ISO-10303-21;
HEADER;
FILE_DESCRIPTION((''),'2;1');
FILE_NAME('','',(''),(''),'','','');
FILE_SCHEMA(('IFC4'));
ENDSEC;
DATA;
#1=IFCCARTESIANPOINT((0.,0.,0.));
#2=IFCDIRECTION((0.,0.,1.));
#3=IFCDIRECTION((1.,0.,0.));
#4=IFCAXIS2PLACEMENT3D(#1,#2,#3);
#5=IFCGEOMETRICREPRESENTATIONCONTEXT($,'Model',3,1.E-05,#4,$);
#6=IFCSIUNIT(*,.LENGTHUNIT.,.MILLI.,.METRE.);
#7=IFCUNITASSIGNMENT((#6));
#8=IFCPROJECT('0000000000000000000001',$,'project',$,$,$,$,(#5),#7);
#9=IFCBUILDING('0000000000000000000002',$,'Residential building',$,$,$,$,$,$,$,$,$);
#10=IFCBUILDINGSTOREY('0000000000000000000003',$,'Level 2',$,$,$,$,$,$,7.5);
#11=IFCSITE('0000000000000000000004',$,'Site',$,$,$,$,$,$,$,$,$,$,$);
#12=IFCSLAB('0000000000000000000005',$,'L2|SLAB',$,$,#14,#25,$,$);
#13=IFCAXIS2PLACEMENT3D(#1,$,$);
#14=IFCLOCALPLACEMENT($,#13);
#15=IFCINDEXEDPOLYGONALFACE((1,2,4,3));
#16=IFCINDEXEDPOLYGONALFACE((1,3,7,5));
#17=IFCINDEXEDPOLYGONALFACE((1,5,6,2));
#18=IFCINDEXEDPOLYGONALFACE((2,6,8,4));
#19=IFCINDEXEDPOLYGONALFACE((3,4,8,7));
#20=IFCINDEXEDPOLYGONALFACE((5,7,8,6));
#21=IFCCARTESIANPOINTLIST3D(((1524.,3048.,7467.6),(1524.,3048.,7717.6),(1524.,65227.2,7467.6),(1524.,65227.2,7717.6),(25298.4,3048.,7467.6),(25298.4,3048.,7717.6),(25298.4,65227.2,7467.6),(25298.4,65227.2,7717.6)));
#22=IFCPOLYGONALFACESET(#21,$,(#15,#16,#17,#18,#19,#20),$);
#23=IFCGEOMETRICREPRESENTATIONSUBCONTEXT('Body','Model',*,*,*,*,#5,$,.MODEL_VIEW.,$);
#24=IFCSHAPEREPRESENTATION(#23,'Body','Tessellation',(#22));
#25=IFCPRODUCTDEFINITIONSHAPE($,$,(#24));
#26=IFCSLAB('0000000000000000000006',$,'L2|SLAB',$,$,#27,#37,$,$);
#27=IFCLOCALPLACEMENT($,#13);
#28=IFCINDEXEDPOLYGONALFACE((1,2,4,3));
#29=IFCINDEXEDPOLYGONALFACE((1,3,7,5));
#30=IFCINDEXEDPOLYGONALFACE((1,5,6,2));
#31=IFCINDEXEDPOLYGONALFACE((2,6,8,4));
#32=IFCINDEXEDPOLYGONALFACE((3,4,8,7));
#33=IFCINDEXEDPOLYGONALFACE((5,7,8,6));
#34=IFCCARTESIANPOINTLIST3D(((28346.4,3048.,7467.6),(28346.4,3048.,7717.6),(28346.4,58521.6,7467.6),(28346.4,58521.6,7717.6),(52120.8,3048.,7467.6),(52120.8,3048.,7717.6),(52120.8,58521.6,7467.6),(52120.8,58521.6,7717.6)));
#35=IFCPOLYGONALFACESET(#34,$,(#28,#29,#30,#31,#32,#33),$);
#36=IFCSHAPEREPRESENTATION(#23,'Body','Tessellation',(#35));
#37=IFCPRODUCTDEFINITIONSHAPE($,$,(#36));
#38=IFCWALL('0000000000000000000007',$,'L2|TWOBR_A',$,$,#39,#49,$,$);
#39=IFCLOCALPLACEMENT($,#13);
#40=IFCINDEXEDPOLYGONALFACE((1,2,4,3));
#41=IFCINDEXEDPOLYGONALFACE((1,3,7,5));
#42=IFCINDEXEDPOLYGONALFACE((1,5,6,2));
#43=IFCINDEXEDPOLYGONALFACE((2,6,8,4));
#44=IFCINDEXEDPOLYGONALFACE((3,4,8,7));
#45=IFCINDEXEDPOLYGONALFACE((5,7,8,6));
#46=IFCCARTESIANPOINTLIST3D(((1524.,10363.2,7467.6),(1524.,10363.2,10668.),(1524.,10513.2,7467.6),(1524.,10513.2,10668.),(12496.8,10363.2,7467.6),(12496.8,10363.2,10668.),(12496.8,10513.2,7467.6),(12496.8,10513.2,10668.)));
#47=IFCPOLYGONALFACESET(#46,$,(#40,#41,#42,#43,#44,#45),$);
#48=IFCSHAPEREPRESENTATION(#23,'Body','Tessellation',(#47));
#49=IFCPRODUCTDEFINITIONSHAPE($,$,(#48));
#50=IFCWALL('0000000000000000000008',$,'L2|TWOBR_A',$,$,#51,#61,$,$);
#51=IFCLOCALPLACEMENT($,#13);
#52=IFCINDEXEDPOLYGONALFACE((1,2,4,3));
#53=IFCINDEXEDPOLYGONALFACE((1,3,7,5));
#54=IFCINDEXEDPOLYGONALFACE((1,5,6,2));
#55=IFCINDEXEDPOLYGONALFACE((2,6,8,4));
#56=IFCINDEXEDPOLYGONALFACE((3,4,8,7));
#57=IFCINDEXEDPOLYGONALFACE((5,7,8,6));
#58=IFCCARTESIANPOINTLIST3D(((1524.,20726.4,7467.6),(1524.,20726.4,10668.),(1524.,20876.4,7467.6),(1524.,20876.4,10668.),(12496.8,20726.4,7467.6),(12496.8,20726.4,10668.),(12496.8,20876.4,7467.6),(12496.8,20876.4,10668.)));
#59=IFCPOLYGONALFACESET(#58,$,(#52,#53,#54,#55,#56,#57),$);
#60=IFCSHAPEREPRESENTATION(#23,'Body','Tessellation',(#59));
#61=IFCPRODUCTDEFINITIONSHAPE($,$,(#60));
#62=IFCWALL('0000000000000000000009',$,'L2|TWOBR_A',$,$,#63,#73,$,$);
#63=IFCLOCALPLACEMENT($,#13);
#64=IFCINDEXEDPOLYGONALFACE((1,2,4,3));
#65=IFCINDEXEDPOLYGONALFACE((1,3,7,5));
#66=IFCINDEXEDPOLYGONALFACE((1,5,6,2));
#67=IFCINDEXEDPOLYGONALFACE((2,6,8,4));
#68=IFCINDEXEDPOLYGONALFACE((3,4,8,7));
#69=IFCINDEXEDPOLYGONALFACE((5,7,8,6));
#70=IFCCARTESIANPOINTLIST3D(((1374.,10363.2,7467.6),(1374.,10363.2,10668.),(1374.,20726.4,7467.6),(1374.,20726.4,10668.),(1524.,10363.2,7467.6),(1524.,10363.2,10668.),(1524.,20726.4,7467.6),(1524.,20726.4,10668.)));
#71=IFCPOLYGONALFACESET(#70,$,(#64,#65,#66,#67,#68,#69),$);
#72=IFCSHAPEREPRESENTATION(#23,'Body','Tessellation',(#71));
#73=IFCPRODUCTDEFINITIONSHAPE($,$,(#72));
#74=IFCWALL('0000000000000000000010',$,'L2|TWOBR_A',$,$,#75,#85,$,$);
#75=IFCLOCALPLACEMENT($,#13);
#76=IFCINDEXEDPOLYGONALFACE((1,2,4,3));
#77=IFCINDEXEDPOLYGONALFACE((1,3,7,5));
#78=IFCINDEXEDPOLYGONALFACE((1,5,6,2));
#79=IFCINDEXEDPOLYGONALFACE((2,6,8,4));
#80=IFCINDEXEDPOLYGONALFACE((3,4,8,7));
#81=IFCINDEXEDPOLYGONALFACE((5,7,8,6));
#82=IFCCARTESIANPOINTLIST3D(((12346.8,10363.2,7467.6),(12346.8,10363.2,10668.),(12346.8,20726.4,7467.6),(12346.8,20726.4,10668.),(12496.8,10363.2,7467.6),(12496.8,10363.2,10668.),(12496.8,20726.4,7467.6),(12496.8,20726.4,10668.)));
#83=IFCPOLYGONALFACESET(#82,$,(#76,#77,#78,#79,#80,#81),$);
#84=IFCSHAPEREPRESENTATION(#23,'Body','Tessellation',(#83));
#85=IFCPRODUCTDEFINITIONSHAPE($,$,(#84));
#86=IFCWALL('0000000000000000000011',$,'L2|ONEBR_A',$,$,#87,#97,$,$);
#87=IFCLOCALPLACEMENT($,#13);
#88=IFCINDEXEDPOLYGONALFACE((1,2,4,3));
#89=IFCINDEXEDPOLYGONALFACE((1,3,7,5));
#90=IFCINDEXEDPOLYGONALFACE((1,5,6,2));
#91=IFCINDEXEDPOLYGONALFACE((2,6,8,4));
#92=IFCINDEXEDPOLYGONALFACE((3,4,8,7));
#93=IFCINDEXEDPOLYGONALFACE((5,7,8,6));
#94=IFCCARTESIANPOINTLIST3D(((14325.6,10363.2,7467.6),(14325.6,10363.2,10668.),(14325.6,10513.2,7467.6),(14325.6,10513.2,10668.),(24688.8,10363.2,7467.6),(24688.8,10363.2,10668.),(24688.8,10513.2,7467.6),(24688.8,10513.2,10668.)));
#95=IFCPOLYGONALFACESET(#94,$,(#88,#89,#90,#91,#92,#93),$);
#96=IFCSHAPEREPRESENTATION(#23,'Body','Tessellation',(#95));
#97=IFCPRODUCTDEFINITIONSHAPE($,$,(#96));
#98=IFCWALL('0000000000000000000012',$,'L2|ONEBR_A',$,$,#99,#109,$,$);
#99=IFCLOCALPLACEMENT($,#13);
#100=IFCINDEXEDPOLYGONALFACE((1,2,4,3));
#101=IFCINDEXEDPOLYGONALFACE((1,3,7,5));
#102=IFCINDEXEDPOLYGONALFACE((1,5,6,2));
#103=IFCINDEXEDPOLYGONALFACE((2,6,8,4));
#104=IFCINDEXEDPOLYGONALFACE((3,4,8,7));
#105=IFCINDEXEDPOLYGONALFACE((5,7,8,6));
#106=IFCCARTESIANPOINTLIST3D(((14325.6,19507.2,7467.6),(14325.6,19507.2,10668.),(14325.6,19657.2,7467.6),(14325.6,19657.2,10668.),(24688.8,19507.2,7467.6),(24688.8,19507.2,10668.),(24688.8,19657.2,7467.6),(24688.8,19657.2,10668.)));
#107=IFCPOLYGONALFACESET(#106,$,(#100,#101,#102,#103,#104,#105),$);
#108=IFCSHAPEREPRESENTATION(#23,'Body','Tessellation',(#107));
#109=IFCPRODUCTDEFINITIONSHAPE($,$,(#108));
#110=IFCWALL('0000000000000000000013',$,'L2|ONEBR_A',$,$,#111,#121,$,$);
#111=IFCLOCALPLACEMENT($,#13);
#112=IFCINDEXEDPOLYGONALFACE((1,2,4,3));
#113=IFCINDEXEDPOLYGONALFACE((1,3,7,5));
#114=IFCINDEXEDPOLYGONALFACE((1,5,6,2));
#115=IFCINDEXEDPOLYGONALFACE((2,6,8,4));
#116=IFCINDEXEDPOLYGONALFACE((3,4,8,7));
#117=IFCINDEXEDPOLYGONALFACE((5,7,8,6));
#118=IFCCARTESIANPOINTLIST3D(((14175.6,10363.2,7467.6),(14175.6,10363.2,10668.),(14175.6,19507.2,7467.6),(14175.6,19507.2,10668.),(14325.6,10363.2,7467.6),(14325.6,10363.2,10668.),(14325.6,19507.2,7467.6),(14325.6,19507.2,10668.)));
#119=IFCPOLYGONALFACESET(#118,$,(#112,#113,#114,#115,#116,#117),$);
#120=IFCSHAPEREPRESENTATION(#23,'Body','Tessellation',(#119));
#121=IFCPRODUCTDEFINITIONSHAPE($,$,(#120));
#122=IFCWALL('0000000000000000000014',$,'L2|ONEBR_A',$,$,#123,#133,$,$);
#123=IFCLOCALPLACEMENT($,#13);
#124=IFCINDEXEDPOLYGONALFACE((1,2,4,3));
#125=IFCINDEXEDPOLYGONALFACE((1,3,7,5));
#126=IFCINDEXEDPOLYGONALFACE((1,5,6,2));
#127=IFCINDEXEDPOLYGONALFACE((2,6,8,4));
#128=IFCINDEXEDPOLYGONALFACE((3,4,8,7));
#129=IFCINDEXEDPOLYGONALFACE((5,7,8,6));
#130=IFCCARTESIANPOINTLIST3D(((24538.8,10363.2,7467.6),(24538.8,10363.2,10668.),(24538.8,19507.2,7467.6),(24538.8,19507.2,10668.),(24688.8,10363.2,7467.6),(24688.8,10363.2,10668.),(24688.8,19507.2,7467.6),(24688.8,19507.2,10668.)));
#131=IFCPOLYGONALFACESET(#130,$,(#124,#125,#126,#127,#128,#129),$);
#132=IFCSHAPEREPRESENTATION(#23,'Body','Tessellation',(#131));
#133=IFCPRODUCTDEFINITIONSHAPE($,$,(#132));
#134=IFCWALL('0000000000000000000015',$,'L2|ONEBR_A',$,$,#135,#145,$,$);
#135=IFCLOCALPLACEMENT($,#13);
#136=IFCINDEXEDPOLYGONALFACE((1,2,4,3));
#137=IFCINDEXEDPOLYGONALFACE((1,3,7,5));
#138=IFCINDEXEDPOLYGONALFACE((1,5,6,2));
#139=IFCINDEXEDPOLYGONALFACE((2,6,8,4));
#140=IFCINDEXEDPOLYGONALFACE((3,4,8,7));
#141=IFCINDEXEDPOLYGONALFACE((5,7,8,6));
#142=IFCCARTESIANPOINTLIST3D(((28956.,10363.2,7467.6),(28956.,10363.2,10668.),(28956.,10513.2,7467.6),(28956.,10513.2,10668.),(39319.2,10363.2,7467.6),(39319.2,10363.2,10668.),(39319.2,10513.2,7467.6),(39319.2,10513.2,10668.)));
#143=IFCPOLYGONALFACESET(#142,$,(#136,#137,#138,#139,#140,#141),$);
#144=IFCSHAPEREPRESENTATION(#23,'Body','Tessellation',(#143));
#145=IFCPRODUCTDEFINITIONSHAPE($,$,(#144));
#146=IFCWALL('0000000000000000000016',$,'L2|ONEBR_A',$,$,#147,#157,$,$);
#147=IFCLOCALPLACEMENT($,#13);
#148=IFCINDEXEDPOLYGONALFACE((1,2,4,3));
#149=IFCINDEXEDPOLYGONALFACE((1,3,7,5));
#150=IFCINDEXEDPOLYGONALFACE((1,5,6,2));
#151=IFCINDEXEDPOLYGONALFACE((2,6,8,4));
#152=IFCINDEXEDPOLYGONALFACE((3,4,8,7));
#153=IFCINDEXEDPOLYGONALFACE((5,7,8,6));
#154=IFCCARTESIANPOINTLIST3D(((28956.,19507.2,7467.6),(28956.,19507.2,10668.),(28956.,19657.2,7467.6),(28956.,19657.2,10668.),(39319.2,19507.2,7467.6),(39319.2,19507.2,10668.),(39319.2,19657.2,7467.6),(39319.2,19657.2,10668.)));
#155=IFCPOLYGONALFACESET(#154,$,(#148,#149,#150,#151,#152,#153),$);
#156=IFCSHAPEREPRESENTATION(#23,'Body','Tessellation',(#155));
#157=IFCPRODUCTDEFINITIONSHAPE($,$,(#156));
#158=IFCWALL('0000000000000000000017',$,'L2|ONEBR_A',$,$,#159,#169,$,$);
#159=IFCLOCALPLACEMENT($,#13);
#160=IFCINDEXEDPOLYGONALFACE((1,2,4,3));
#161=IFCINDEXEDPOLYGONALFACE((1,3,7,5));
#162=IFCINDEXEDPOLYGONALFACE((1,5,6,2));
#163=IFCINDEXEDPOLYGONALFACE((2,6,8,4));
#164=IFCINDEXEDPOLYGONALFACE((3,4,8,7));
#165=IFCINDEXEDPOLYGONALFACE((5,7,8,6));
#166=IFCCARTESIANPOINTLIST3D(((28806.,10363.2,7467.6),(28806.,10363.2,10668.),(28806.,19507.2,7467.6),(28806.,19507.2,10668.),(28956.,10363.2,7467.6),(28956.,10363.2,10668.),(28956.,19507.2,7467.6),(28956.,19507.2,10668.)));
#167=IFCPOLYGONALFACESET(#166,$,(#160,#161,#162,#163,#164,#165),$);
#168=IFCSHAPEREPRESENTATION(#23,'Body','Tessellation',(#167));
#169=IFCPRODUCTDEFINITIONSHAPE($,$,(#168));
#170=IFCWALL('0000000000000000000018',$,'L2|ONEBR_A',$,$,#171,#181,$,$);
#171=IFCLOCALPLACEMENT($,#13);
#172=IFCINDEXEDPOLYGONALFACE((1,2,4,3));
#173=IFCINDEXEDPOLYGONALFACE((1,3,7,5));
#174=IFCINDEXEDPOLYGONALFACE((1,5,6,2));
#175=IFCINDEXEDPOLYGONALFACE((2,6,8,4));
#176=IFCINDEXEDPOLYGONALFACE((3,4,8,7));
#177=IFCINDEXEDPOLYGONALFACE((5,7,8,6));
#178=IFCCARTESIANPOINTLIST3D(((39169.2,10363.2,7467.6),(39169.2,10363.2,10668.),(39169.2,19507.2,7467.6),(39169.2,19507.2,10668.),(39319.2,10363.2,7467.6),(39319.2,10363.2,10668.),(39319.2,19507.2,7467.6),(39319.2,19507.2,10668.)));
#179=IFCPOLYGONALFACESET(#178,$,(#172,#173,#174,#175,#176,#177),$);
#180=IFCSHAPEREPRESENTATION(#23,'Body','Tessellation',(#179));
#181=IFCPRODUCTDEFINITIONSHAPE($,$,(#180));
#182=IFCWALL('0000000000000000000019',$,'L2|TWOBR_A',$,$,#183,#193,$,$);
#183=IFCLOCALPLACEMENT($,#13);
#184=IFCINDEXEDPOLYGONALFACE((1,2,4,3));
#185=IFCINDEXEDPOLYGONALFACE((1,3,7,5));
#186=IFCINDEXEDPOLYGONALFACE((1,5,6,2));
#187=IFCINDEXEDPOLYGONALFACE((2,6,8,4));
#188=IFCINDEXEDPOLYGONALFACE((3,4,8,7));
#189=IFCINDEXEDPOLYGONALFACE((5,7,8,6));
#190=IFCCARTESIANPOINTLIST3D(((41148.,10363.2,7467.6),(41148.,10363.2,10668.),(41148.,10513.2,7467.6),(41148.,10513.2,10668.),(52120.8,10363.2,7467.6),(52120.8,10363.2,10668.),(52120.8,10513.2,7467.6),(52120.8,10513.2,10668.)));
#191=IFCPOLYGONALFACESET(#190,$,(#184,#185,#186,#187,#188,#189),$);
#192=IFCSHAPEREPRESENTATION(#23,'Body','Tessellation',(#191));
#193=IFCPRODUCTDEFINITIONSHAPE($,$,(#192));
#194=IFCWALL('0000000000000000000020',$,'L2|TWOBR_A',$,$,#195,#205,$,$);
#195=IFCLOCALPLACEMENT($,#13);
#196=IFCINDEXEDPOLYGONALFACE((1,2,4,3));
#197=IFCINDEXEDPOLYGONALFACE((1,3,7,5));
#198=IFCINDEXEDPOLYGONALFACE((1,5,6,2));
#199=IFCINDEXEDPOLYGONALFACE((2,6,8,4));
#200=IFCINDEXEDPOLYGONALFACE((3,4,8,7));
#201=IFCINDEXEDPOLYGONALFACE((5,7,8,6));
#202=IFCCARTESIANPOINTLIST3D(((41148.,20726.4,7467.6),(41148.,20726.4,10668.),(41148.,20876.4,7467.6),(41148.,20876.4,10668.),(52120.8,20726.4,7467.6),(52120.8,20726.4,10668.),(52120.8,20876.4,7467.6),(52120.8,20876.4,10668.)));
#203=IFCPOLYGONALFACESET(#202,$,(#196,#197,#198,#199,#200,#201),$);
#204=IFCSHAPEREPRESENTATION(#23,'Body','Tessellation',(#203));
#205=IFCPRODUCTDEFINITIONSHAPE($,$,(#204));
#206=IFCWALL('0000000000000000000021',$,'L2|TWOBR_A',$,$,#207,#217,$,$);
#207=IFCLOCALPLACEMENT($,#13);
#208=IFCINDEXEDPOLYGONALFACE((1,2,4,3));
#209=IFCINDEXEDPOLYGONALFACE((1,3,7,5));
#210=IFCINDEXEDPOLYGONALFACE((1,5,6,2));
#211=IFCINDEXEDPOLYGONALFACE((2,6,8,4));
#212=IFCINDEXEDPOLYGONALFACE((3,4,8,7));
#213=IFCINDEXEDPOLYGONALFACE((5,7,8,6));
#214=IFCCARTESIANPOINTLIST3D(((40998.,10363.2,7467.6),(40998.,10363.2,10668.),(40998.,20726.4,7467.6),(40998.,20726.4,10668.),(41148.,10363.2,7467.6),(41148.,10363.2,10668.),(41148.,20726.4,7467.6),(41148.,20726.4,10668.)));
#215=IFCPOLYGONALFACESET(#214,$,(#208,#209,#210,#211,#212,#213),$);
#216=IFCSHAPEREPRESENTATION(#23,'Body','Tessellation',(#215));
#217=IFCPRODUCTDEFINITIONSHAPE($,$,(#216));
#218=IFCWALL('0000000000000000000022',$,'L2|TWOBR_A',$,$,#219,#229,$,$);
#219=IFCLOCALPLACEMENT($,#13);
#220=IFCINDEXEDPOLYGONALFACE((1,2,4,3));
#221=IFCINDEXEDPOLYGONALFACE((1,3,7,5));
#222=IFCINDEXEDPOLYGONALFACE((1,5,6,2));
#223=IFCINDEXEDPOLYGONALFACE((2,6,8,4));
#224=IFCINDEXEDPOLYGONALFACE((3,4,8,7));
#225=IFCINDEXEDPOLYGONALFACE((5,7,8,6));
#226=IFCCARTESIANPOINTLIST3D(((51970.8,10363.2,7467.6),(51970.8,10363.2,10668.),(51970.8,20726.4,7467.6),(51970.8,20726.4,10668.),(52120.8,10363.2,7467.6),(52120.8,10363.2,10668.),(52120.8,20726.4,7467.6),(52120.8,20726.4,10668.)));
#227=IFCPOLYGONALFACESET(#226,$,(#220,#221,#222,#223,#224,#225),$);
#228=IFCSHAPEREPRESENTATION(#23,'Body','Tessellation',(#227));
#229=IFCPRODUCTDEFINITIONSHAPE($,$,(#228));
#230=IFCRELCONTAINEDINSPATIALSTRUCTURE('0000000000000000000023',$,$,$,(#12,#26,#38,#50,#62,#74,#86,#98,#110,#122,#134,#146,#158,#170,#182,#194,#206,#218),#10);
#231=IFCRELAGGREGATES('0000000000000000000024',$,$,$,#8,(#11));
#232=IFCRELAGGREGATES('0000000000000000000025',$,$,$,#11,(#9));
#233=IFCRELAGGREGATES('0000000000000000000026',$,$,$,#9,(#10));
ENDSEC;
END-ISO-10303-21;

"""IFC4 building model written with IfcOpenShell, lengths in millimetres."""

from ifc_helpers import new_model, si_unit, frame, origin_with_axes, place, context, subcontext, project, spatial, indexed_curve, outline, extrude, element, save


model = new_model("IFC4")

# Units and contexts
model_context = context("Model", 3, precision=1e-05, world=origin_with_axes())
body_context = subcontext(model_context, "Body", "Model", "MODEL_VIEW")
ifc_project = project(units=[si_unit("LENGTHUNIT", "METRE", prefix="MILLI")], contexts=[model_context])

# Site, building, storey
site = spatial("IfcSite", under=ifc_project, Name="Site")
building = spatial("IfcBuilding", under=site, Name="Residential building")
storey = spatial("IfcBuildingStorey", under=building, Name="Level 2", Elevation=7.5)

# Slabs
slab_1_placement = place(None, frame((1524.0, 3048.0, 7467.6), z_axis=(0.0, 0.0, 1.0), x_axis=(1.0, 0.0, 0.0)))
element("IfcSlab", 1, at=slab_1_placement, inside=storey, Name="L2|SLAB", context=body_context, shape_type="SweptSolid", body=[
    extrude(outline(indexed_curve([(0.0, 0.0), (23774.4, 0.0), (23774.4, 62179.2), (0.0, 62179.2), (0.0, 0.0)])), None, (0.0, 0.0, 1.0), 250.0),
])
slab_2_placement = place(None, frame((28346.4, 3048.0, 7467.6), z_axis=(0.0, 0.0, 1.0), x_axis=(1.0, 0.0, 0.0)))
element("IfcSlab", 2, at=slab_2_placement, inside=storey, Name="L2|SLAB", context=body_context, shape_type="SweptSolid", body=[
    extrude(outline(indexed_curve([(0.0, 0.0), (23774.4, 0.0), (23774.4, 55473.6), (0.0, 55473.6), (0.0, 0.0)])), None, (0.0, 0.0, 1.0), 250.0),
])

# Walls
for number, where, z_axis, x_axis, name in (
    (3, (1524.0, 10363.2, 7467.6), (0.0, 0.0, 1.0), (1.0, 0.0, 0.0), "L2|TWOBR_A"),
    (4, (1524.0, 20726.4, 7467.6), (0.0, 0.0, 1.0), (1.0, 0.0, 0.0), "L2|TWOBR_A"),
):
    element("IfcWall", number, at=place(None, frame(where, z_axis=z_axis, x_axis=x_axis)), inside=storey, Name=name, context=body_context, shape_type="SweptSolid", body=[
        extrude(outline(indexed_curve([(0.0, 0.0), (0.0, 150.0), (10972.8, 150.0), (10972.8, 0.0), (0.0, 0.0)], self_intersect=False)), origin_with_axes(), (0.0, 0.0, 1.0), 3200.4),
    ])
for number, where, z_axis, x_axis, name in (
    (5, (1524.0, 10363.2, 7467.6), (0.0, 0.0, 1.0), (0.0, 1.0, 0.0), "L2|TWOBR_A"),
    (6, (12496.8, 10363.2, 7467.6), (0.0, 0.0, 1.0), (0.0, 1.0, 0.0), "L2|TWOBR_A"),
    (7, (14325.6, 10363.2, 7467.6), (0.0, 0.0, 1.0), (1.0, 0.0, 0.0), "L2|ONEBR_A"),
    (8, (14325.6, 19507.2, 7467.6), (0.0, 0.0, 1.0), (1.0, 0.0, 0.0), "L2|ONEBR_A"),
):
    element("IfcWall", number, at=place(None, frame(where, z_axis=z_axis, x_axis=x_axis)), inside=storey, Name=name, context=body_context, shape_type="SweptSolid", body=[
        extrude(outline(indexed_curve([(0.0, 0.0), (0.0, 150.0), (10363.2, 150.0), (10363.2, 0.0), (0.0, 0.0)], self_intersect=False)), origin_with_axes(), (0.0, 0.0, 1.0), 3200.4),
    ])
for number, where, z_axis, x_axis, name in (
    (9, (14325.6, 10363.2, 7467.6), (0.0, 0.0, 1.0), (0.0, 1.0, 0.0), "L2|ONEBR_A"),
    (10, (24688.8, 10363.2, 7467.6), (0.0, 0.0, 1.0), (0.0, 1.0, 0.0), "L2|ONEBR_A"),
):
    element("IfcWall", number, at=place(None, frame(where, z_axis=z_axis, x_axis=x_axis)), inside=storey, Name=name, context=body_context, shape_type="SweptSolid", body=[
        extrude(outline(indexed_curve([(0.0, 0.0), (0.0, 150.0), (9144.0, 150.0), (9144.0, 0.0), (0.0, 0.0)], self_intersect=False)), origin_with_axes(), (0.0, 0.0, 1.0), 3200.4),
    ])
for number, where, z_axis, x_axis, name in (
    (11, (28956.0, 10363.2, 7467.6), (0.0, 0.0, 1.0), (1.0, 0.0, 0.0), "L2|ONEBR_A"),
    (12, (28956.0, 19507.2, 7467.6), (0.0, 0.0, 1.0), (1.0, 0.0, 0.0), "L2|ONEBR_A"),
):
    element("IfcWall", number, at=place(None, frame(where, z_axis=z_axis, x_axis=x_axis)), inside=storey, Name=name, context=body_context, shape_type="SweptSolid", body=[
        extrude(outline(indexed_curve([(0.0, 0.0), (0.0, 150.0), (10363.2, 150.0), (10363.2, 0.0), (0.0, 0.0)], self_intersect=False)), origin_with_axes(), (0.0, 0.0, 1.0), 3200.4),
    ])
for number, where, z_axis, x_axis, name in (
    (13, (28956.0, 10363.2, 7467.6), (0.0, 0.0, 1.0), (0.0, 1.0, 0.0), "L2|ONEBR_A"),
    (14, (39319.2, 10363.2, 7467.6), (0.0, 0.0, 1.0), (0.0, 1.0, 0.0), "L2|ONEBR_A"),
):
    element("IfcWall", number, at=place(None, frame(where, z_axis=z_axis, x_axis=x_axis)), inside=storey, Name=name, context=body_context, shape_type="SweptSolid", body=[
        extrude(outline(indexed_curve([(0.0, 0.0), (0.0, 150.0), (9144.0, 150.0), (9144.0, 0.0), (0.0, 0.0)], self_intersect=False)), origin_with_axes(), (0.0, 0.0, 1.0), 3200.4),
    ])
for number, where, z_axis, x_axis, name in (
    (15, (41148.0, 10363.2, 7467.6), (0.0, 0.0, 1.0), (1.0, 0.0, 0.0), "L2|TWOBR_A"),
    (16, (41148.0, 20726.4, 7467.6), (0.0, 0.0, 1.0), (1.0, 0.0, 0.0), "L2|TWOBR_A"),
):
    element("IfcWall", number, at=place(None, frame(where, z_axis=z_axis, x_axis=x_axis)), inside=storey, Name=name, context=body_context, shape_type="SweptSolid", body=[
        extrude(outline(indexed_curve([(0.0, 0.0), (0.0, 150.0), (10972.8, 150.0), (10972.8, 0.0), (0.0, 0.0)], self_intersect=False)), origin_with_axes(), (0.0, 0.0, 1.0), 3200.4),
    ])
for number, where, z_axis, x_axis, name in (
    (17, (41148.0, 10363.2, 7467.6), (0.0, 0.0, 1.0), (0.0, 1.0, 0.0), "L2|TWOBR_A"),
    (18, (52120.8, 10363.2, 7467.6), (0.0, 0.0, 1.0), (0.0, 1.0, 0.0), "L2|TWOBR_A"),
):
    element("IfcWall", number, at=place(None, frame(where, z_axis=z_axis, x_axis=x_axis)), inside=storey, Name=name, context=body_context, shape_type="SweptSolid", body=[
        extrude(outline(indexed_curve([(0.0, 0.0), (0.0, 150.0), (10363.2, 150.0), (10363.2, 0.0), (0.0, 0.0)], self_intersect=False)), origin_with_axes(), (0.0, 0.0, 1.0), 3200.4),
    ])

save(model, "model.ifc")
